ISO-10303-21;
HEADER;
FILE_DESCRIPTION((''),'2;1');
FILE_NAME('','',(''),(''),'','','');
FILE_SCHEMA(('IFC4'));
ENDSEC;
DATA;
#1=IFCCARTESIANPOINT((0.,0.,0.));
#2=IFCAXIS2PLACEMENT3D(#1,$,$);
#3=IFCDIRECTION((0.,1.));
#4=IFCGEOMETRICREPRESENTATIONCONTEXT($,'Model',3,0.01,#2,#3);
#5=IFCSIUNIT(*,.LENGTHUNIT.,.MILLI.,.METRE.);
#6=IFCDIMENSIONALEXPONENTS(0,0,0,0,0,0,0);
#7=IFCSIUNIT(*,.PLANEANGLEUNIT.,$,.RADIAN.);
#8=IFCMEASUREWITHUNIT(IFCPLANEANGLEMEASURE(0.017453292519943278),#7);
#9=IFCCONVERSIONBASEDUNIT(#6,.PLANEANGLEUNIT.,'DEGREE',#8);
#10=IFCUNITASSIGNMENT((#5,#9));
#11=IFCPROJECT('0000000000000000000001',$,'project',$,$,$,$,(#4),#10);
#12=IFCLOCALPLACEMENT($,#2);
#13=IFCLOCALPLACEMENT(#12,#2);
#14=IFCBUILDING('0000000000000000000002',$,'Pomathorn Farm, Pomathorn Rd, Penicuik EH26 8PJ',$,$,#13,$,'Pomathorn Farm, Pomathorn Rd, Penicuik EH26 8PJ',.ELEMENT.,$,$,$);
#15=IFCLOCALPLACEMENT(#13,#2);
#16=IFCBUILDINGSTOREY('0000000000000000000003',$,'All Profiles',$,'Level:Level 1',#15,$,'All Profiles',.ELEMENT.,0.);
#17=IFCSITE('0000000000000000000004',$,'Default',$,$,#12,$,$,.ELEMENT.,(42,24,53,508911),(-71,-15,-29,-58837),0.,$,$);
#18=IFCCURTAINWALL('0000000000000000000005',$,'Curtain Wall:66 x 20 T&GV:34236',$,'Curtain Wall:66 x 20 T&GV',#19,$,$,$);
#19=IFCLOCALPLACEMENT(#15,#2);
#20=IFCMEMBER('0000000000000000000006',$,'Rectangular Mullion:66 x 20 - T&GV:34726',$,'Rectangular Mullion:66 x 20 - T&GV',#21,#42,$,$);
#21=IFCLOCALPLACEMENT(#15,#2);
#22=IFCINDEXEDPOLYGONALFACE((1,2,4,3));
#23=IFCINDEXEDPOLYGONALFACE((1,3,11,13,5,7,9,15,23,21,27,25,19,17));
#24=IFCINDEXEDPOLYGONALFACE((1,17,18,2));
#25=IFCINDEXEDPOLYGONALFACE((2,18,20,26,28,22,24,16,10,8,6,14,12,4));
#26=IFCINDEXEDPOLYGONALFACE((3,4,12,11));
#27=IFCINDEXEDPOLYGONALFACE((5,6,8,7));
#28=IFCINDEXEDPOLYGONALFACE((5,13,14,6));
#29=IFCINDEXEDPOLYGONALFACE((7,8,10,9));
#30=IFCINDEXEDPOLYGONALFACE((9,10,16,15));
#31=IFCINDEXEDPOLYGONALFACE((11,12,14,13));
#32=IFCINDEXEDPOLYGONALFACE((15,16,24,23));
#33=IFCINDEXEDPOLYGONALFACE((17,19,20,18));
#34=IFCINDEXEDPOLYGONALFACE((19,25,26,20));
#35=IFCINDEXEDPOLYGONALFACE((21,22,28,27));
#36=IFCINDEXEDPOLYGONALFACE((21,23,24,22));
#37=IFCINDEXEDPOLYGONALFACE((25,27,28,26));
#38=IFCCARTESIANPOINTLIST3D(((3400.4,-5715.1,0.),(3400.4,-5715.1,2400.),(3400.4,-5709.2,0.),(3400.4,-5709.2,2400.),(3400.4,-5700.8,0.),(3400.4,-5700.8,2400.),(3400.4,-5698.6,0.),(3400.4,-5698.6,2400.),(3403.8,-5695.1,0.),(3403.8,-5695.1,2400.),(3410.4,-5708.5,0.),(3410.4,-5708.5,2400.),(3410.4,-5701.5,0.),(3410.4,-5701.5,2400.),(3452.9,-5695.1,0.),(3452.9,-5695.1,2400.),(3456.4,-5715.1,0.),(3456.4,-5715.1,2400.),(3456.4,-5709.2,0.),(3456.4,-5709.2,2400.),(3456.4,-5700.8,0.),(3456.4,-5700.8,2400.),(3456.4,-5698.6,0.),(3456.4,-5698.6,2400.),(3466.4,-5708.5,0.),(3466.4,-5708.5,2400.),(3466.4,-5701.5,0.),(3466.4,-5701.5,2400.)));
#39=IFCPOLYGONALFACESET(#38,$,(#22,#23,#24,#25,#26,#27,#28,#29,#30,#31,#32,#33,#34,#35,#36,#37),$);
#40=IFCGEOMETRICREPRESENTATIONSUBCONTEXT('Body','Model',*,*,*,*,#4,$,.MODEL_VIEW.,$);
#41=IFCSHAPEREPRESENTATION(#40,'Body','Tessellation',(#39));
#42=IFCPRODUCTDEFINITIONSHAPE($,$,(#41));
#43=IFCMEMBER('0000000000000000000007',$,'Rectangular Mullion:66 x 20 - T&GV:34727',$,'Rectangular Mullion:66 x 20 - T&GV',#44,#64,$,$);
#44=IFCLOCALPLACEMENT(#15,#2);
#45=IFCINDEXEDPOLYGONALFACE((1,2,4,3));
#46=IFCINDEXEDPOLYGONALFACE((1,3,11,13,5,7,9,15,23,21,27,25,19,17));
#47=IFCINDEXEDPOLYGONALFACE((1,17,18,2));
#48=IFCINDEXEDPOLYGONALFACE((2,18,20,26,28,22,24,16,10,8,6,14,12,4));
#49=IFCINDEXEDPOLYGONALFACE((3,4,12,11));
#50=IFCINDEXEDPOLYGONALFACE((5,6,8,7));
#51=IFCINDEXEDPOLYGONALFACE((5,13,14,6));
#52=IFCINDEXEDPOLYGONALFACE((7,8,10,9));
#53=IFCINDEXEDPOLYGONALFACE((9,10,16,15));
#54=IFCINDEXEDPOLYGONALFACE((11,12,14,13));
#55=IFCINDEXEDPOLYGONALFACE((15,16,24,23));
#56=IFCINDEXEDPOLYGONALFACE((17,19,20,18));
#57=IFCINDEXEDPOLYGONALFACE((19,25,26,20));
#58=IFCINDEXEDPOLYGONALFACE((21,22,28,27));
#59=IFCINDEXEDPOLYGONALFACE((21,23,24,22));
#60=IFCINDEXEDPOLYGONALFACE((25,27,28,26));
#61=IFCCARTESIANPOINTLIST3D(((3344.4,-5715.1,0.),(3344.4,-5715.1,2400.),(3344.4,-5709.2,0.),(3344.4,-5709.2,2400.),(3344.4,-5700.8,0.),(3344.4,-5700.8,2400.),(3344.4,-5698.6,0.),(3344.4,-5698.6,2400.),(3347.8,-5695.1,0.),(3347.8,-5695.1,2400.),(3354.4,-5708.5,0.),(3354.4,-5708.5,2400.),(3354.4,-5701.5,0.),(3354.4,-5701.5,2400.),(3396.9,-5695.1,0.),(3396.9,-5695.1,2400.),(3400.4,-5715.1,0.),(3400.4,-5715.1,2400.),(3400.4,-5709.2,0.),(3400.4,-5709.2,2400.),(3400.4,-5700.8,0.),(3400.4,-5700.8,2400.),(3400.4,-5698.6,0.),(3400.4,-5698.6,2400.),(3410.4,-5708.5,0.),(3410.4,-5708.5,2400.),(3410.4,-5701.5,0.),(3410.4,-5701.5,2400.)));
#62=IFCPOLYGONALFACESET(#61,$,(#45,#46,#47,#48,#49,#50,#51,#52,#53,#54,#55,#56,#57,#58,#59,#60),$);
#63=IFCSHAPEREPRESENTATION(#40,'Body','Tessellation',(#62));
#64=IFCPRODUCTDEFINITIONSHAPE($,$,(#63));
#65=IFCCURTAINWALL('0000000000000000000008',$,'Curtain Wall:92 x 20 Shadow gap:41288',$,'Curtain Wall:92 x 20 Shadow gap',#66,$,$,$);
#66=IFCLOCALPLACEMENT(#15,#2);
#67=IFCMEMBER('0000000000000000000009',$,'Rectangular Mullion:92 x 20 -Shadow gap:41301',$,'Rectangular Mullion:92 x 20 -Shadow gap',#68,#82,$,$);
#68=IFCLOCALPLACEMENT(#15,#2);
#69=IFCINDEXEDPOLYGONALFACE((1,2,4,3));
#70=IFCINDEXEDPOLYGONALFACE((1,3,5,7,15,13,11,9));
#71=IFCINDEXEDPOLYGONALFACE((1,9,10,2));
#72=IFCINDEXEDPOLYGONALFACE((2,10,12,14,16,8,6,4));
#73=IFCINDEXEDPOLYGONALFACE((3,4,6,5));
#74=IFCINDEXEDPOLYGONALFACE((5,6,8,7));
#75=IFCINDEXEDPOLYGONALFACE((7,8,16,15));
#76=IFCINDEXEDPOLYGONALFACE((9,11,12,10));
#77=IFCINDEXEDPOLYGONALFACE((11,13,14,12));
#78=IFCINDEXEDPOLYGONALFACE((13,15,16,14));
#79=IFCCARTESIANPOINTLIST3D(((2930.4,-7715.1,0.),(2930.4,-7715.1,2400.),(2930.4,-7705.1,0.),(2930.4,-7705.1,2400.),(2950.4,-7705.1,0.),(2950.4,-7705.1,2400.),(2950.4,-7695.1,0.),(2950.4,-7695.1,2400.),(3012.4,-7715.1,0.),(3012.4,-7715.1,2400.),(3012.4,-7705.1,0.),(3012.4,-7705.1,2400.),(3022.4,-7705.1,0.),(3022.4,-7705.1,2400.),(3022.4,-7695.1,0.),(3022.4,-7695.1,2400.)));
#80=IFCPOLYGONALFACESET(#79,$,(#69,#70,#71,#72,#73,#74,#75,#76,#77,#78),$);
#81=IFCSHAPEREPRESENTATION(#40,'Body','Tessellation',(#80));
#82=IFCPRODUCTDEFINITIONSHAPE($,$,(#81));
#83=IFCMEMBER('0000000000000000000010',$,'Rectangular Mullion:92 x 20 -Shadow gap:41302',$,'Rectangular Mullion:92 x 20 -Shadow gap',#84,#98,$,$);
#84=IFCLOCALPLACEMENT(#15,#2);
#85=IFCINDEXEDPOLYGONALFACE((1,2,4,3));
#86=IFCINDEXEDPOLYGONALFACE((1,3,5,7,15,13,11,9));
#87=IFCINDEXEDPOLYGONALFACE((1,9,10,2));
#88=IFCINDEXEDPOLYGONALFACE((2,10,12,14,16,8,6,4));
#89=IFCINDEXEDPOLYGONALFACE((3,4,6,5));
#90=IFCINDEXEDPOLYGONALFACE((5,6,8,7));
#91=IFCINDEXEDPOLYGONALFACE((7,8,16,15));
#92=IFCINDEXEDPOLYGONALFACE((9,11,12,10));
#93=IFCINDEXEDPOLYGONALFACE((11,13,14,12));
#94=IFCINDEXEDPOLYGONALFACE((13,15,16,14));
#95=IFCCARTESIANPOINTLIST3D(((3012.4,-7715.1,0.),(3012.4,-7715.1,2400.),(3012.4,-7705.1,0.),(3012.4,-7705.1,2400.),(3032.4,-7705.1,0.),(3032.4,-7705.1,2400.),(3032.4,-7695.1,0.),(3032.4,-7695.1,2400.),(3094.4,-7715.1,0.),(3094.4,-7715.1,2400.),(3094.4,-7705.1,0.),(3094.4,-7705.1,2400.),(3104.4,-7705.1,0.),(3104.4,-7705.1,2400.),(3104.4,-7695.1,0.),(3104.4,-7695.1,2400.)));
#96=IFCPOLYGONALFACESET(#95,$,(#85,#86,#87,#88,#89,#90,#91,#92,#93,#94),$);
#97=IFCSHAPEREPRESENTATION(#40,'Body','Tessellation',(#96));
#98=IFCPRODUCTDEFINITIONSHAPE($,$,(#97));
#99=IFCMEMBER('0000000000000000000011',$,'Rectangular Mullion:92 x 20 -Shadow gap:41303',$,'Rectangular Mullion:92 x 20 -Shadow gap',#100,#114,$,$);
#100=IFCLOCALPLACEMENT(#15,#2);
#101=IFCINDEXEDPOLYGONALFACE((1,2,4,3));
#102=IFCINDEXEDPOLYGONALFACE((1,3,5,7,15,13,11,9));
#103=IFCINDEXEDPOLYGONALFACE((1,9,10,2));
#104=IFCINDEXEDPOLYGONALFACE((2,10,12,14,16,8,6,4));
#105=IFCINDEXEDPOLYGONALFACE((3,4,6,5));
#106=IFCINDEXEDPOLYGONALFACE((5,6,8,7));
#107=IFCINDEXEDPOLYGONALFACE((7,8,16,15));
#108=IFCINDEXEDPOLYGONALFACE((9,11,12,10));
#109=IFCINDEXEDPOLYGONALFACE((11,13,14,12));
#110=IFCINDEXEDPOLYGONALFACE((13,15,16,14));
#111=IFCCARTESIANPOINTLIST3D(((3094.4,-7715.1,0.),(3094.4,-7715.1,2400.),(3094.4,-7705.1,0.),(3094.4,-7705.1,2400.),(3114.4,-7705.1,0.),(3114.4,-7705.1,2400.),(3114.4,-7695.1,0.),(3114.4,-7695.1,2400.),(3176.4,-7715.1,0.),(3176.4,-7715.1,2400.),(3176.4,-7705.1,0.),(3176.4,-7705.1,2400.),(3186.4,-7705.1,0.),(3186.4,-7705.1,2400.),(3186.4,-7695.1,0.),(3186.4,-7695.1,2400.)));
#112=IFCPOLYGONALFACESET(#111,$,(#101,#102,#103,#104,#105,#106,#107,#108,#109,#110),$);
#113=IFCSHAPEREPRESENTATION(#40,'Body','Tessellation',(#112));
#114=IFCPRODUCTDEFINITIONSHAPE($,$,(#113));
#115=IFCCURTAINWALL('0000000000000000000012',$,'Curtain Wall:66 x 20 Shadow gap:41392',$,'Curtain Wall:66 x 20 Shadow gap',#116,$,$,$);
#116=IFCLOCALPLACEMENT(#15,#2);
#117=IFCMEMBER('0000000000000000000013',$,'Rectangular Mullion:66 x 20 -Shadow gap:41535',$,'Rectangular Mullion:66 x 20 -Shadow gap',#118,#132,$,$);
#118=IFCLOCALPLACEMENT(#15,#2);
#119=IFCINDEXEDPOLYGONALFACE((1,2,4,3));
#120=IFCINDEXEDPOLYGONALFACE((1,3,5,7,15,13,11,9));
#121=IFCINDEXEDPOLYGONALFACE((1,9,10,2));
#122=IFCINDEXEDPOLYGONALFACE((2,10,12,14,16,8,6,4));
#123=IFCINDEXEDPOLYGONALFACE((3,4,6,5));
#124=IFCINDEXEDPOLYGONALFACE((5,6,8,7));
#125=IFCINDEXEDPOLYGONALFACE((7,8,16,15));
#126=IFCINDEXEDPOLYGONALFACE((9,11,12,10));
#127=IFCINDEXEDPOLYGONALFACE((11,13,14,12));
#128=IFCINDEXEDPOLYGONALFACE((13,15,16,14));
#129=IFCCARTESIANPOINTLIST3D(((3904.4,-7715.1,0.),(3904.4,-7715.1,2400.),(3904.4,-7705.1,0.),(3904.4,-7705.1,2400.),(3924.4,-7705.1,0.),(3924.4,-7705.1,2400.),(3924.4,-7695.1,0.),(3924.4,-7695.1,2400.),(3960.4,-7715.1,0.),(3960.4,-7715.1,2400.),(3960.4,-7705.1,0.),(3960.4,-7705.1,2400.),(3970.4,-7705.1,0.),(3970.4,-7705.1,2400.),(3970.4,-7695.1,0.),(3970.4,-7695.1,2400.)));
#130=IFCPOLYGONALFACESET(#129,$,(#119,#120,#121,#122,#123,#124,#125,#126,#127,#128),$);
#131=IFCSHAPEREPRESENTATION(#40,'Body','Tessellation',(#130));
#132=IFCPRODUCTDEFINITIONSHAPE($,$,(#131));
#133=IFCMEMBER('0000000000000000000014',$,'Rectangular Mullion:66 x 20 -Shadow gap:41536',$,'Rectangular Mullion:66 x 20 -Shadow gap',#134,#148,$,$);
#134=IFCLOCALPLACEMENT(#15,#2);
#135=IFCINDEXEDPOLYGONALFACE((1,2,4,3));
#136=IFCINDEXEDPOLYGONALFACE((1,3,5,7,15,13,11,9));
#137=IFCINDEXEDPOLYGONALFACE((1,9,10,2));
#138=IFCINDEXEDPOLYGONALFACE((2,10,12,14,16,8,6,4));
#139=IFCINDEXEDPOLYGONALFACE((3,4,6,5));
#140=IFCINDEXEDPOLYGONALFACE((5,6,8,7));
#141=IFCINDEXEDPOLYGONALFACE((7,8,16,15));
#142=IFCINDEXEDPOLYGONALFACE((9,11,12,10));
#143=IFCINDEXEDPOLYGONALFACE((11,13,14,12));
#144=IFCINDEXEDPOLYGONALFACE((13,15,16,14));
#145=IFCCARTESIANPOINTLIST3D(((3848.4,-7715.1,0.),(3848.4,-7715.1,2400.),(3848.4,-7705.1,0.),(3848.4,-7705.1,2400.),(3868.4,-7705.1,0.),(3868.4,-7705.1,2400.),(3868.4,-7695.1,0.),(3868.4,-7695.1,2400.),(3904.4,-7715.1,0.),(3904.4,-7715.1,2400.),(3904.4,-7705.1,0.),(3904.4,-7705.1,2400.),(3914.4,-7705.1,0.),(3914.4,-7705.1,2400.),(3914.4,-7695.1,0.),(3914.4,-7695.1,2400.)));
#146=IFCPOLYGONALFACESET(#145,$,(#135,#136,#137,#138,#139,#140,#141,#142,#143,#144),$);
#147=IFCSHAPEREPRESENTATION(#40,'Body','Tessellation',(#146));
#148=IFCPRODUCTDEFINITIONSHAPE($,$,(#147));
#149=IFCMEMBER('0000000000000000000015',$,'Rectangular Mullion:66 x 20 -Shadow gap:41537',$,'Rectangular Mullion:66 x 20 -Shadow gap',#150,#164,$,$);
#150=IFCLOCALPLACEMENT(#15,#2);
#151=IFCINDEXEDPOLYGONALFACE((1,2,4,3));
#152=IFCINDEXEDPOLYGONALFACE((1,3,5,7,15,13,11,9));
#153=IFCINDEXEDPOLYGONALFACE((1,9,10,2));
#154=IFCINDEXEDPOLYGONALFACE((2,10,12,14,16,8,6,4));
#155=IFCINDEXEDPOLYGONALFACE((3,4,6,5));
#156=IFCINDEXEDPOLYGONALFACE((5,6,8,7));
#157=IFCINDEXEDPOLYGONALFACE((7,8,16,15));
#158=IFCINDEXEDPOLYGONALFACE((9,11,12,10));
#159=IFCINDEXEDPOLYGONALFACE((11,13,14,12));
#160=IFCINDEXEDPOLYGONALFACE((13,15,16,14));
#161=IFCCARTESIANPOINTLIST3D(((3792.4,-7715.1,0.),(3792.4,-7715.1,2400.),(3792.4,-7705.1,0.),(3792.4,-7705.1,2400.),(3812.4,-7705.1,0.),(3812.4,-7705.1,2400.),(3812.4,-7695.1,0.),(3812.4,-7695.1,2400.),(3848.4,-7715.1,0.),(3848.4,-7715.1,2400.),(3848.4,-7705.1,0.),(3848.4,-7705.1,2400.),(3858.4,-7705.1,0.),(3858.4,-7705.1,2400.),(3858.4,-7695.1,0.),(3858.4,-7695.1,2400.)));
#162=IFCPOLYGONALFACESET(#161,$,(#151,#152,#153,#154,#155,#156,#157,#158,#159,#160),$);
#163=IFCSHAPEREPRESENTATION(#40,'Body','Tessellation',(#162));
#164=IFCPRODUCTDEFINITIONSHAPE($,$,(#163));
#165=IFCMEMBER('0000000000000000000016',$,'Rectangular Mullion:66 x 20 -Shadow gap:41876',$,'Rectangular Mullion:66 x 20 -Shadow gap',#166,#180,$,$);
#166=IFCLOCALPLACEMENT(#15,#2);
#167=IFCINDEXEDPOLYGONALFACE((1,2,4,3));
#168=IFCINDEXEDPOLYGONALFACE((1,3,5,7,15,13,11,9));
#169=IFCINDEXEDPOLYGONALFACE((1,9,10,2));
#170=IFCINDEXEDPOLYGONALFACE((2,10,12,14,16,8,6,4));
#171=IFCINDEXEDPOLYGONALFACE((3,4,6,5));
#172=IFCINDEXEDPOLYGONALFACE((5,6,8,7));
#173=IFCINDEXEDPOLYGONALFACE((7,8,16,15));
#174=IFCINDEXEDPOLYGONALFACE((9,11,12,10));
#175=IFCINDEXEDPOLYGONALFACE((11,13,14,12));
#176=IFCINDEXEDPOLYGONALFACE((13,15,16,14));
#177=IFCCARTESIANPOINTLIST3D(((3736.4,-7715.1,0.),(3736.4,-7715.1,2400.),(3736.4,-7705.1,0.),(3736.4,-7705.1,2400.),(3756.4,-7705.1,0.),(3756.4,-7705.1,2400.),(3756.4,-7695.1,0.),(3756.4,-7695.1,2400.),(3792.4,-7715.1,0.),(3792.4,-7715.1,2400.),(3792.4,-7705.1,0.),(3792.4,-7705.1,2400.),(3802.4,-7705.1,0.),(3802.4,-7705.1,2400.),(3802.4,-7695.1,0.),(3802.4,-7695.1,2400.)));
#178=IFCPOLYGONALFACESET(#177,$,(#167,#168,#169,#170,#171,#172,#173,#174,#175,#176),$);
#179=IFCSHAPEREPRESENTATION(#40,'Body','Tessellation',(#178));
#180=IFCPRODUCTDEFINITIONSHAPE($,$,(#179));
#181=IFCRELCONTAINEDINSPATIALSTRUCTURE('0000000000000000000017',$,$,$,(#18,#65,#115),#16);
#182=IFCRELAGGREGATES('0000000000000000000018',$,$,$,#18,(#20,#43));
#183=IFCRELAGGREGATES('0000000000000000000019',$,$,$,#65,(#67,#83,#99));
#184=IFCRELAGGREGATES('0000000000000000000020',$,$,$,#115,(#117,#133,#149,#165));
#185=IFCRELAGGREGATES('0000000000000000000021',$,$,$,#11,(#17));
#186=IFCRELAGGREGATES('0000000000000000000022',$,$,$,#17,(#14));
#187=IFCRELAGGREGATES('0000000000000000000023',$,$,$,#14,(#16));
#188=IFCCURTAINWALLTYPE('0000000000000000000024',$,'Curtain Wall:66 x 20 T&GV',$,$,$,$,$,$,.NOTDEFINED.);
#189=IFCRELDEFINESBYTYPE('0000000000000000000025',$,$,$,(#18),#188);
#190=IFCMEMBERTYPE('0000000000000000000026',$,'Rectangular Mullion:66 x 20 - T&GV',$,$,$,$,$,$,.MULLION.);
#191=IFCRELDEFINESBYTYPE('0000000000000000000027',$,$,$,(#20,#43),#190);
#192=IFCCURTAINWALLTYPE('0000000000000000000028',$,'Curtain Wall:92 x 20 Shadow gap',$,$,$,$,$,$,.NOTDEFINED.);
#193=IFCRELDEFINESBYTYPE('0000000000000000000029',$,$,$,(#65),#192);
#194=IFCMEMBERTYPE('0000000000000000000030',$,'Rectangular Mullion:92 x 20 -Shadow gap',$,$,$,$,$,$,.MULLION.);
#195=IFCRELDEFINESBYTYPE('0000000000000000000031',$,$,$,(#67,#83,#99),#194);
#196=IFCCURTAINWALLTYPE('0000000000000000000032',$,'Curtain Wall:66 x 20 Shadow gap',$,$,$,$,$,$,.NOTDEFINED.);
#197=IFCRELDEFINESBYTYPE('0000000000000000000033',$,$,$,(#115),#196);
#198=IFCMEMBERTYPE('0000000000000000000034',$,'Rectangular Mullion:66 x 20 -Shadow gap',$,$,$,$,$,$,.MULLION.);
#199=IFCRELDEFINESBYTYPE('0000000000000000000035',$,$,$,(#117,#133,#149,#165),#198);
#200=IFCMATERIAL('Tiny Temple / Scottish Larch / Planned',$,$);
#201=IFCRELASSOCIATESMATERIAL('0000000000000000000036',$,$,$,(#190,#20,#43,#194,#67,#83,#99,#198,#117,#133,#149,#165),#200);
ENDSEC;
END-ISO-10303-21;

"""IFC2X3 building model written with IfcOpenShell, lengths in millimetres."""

from ifc_helpers import new_model, entity, si_unit, converted_unit, direction, frame, origin, place, context, subcontext, project, spatial, polyline, outline, extrude, source, transform, mapped, material, type_object, type_shapes, element, aggregate, save


model = new_model("IFC2X3")

# Units and contexts
model_context = context("Model", 3, precision=0.01, world=origin(), true_north=direction((0.0, 1.0)))
body_context = subcontext(model_context, "Body", "Model", "MODEL_VIEW")
ifc_project = project(units=[si_unit("LENGTHUNIT", "METRE", prefix="MILLI"), converted_unit("PLANEANGLEUNIT", "DEGREE", entity("IfcPlaneAngleMeasure", 0.017453292519943278), si_unit("PLANEANGLEUNIT", "RADIAN"), dimensions=[0, 0, 0, 0, 0, 0, 0])], contexts=[model_context])

# Site, building, storey
site_placement = place(None, origin())
site = spatial("IfcSite", under=ifc_project, at=site_placement, Name="Default", CompositionType="ELEMENT", RefLatitude=(42, 24, 53, 508911), RefLongitude=(-71, -15, -29, -58837), RefElevation=0.0)
building_placement = place(site_placement, origin())
building = spatial("IfcBuilding", under=site, at=building_placement, Name="Pomathorn Farm, Pomathorn Rd, Penicuik EH26 8PJ", LongName="Pomathorn Farm, Pomathorn Rd, Penicuik EH26 8PJ", CompositionType="ELEMENT")
storey_placement = place(building_placement, origin())
storey = spatial("IfcBuildingStorey", under=building, at=storey_placement, Name="All Profiles", ObjectType="Level:Level 1", LongName="All Profiles", CompositionType="ELEMENT", Elevation=0.0)

# Curtain walls, members
curtain_wall_type_1 = type_object("IfcCurtainWallType", Name="Curtain Wall:66 x 20 T&GV", PredefinedType="NOTDEFINED")
curtain_wall_1_placement = place(storey_placement, origin())
curtain_wall_1 = element("IfcCurtainWall", 1, at=curtain_wall_1_placement, inside=storey, type_object=curtain_wall_type_1, Name="Curtain Wall:66 x 20 T&GV:34236", ObjectType="Curtain Wall:66 x 20 T&GV")
ifc_material = material(Name="Tiny Temple / Scottish Larch / Planned")
member_type_1 = type_object("IfcMemberType", Name="Rectangular Mullion:66 x 20 - T&GV", PredefinedType="MULLION", material=ifc_material)
shared_shape_1 = source(origin(), body_context, "Body", "SweptSolid", [
    extrude(outline(polyline([(-25.1, -11.0), (30.9, -11.0), (30.9, -5.1), (20.9, -4.4), (20.9, 2.6), (30.9, 3.3), (30.9, 5.5), (27.4, 9.0), (-21.7, 9.0), (-25.1, 5.5), (-25.1, 3.3), (-35.1, 2.6), (-35.1, -4.4), (-25.1, -5.1), (-25.1, -11.0)])), frame((-35.1, -11.0, -2400.0), z_axis=(0.0, 0.0, 1.0), x_axis=(-1.0, 0.0, 0.0)), (0.0, 0.0, 1.0), 2400.0),
])
type_shapes(member_type_1, [shared_shape_1])
member_1_placement = place(curtain_wall_1_placement, frame((3466.4, -5715.1, 0.0), z_axis=(0.0, 0.0, -1.0), x_axis=(1.0, 0.0, 0.0)))
member_1 = element("IfcMember", 2, at=member_1_placement, type_object=member_type_1, material=ifc_material, Name="Rectangular Mullion:66 x 20 - T&GV:34726", ObjectType="Rectangular Mullion:66 x 20 - T&GV", context=body_context, shape_type="MappedRepresentation", body=[
    mapped(shared_shape_1, transform((0.0, 0.0, 0.0), scale=1.0)),
])
member_2_placement = place(curtain_wall_1_placement, frame((3410.4, -5715.1, 0.0), z_axis=(0.0, 0.0, -1.0), x_axis=(1.0, 0.0, 0.0)))
member_2 = element("IfcMember", 3, at=member_2_placement, type_object=member_type_1, material=ifc_material, Name="Rectangular Mullion:66 x 20 - T&GV:34727", ObjectType="Rectangular Mullion:66 x 20 - T&GV", context=body_context, shape_type="MappedRepresentation", body=[
    mapped(shared_shape_1, transform((0.0, 0.0, 0.0), scale=1.0)),
])
aggregate(curtain_wall_1, [member_1, member_2])
curtain_wall_type_2 = type_object("IfcCurtainWallType", Name="Curtain Wall:92 x 20 Shadow gap", PredefinedType="NOTDEFINED")
curtain_wall_2_placement = place(storey_placement, origin())
curtain_wall_2 = element("IfcCurtainWall", 4, at=curtain_wall_2_placement, inside=storey, type_object=curtain_wall_type_2, Name="Curtain Wall:92 x 20 Shadow gap:41288", ObjectType="Curtain Wall:92 x 20 Shadow gap")
member_type_2 = type_object("IfcMemberType", Name="Rectangular Mullion:92 x 20 -Shadow gap", PredefinedType="MULLION", material=ifc_material)
shared_shape_2 = source(origin(), body_context, "Body", "SweptSolid", [
    extrude(outline(polyline([(-48.5, 0.0), (-48.5, -10.0), (33.5, -10.0), (33.5, 0.0), (43.5, 0.0), (43.5, 10.0), (-28.5, 10.0), (-28.5, 0.0), (-48.5, 0.0)])), frame((-43.5, -10.0, -2400.0), z_axis=(0.0, 0.0, -1.0), x_axis=(1.0, 0.0, 0.0)), (0.0, 0.0, -1.0), 2400.0),
])
type_shapes(member_type_2, [shared_shape_2])
member_3_placement = place(curtain_wall_2_placement, frame((3022.4, -7715.1, 0.0), z_axis=(0.0, 0.0, -1.0), x_axis=(1.0, 0.0, 0.0)))
member_3 = element("IfcMember", 5, at=member_3_placement, type_object=member_type_2, material=ifc_material, Name="Rectangular Mullion:92 x 20 -Shadow gap:41301", ObjectType="Rectangular Mullion:92 x 20 -Shadow gap", context=body_context, shape_type="MappedRepresentation", body=[
    mapped(shared_shape_2, transform((0.0, 0.0, 0.0), scale=1.0)),
])
member_4_placement = place(curtain_wall_2_placement, frame((3104.4, -7715.1, 0.0), z_axis=(0.0, 0.0, -1.0), x_axis=(1.0, 0.0, 0.0)))
member_4 = element("IfcMember", 6, at=member_4_placement, type_object=member_type_2, material=ifc_material, Name="Rectangular Mullion:92 x 20 -Shadow gap:41302", ObjectType="Rectangular Mullion:92 x 20 -Shadow gap", context=body_context, shape_type="MappedRepresentation", body=[
    mapped(shared_shape_2, transform((0.0, 0.0, 0.0), scale=1.0)),
])
member_5_placement = place(curtain_wall_2_placement, frame((3186.4, -7715.1, 0.0), z_axis=(0.0, 0.0, -1.0), x_axis=(1.0, 0.0, 0.0)))
member_5 = element("IfcMember", 7, at=member_5_placement, type_object=member_type_2, material=ifc_material, Name="Rectangular Mullion:92 x 20 -Shadow gap:41303", ObjectType="Rectangular Mullion:92 x 20 -Shadow gap", context=body_context, shape_type="MappedRepresentation", body=[
    mapped(shared_shape_2, transform((0.0, 0.0, 0.0), scale=1.0)),
])
aggregate(curtain_wall_2, [member_3, member_4, member_5])
curtain_wall_type_3 = type_object("IfcCurtainWallType", Name="Curtain Wall:66 x 20 Shadow gap", PredefinedType="NOTDEFINED")
curtain_wall_3_placement = place(storey_placement, origin())
curtain_wall_3 = element("IfcCurtainWall", 8, at=curtain_wall_3_placement, inside=storey, type_object=curtain_wall_type_3, Name="Curtain Wall:66 x 20 Shadow gap:41392", ObjectType="Curtain Wall:66 x 20 Shadow gap")
member_type_3 = type_object("IfcMemberType", Name="Rectangular Mullion:66 x 20 -Shadow gap", PredefinedType="MULLION", material=ifc_material)
shared_shape_3 = source(origin(), body_context, "Body", "SweptSolid", [
    extrude(outline(polyline([(-35.5, 0.0), (-35.5, -10.0), (20.5, -10.0), (20.5, 0.0), (30.5, 0.0), (30.5, 10.0), (-15.5, 10.0), (-15.5, 0.0), (-35.5, 0.0)])), frame((-30.5, -10.0, -2400.0), z_axis=(0.0, 0.0, -1.0), x_axis=(1.0, 0.0, 0.0)), (0.0, 0.0, -1.0), 2400.0),
])
type_shapes(member_type_3, [shared_shape_3])
member_6_placement = place(curtain_wall_3_placement, frame((3970.4, -7715.1, 0.0), z_axis=(0.0, 0.0, -1.0), x_axis=(1.0, 0.0, 0.0)))
member_6 = element("IfcMember", 9, at=member_6_placement, type_object=member_type_3, material=ifc_material, Name="Rectangular Mullion:66 x 20 -Shadow gap:41535", ObjectType="Rectangular Mullion:66 x 20 -Shadow gap", context=body_context, shape_type="MappedRepresentation", body=[
    mapped(shared_shape_3, transform((0.0, 0.0, 0.0), scale=1.0)),
])
member_7_placement = place(curtain_wall_3_placement, frame((3914.4, -7715.1, 0.0), z_axis=(0.0, 0.0, -1.0), x_axis=(1.0, 0.0, 0.0)))
member_7 = element("IfcMember", 10, at=member_7_placement, type_object=member_type_3, material=ifc_material, Name="Rectangular Mullion:66 x 20 -Shadow gap:41536", ObjectType="Rectangular Mullion:66 x 20 -Shadow gap", context=body_context, shape_type="MappedRepresentation", body=[
    mapped(shared_shape_3, transform((0.0, 0.0, 0.0), scale=1.0)),
])
member_8_placement = place(curtain_wall_3_placement, frame((3858.4, -7715.1, 0.0), z_axis=(0.0, 0.0, -1.0), x_axis=(1.0, 0.0, 0.0)))
member_8 = element("IfcMember", 11, at=member_8_placement, type_object=member_type_3, material=ifc_material, Name="Rectangular Mullion:66 x 20 -Shadow gap:41537", ObjectType="Rectangular Mullion:66 x 20 -Shadow gap", context=body_context, shape_type="MappedRepresentation", body=[
    mapped(shared_shape_3, transform((0.0, 0.0, 0.0), scale=1.0)),
])
member_9_placement = place(curtain_wall_3_placement, frame((3802.4, -7715.1, 0.0), z_axis=(0.0, 0.0, -1.0), x_axis=(1.0, 0.0, 0.0)))
member_9 = element("IfcMember", 12, at=member_9_placement, type_object=member_type_3, material=ifc_material, Name="Rectangular Mullion:66 x 20 -Shadow gap:41876", ObjectType="Rectangular Mullion:66 x 20 -Shadow gap", context=body_context, shape_type="MappedRepresentation", body=[
    mapped(shared_shape_3, transform((0.0, 0.0, 0.0), scale=1.0)),
])
aggregate(curtain_wall_3, [member_6, member_7, member_8, member_9])

save(model, "model.ifc")
